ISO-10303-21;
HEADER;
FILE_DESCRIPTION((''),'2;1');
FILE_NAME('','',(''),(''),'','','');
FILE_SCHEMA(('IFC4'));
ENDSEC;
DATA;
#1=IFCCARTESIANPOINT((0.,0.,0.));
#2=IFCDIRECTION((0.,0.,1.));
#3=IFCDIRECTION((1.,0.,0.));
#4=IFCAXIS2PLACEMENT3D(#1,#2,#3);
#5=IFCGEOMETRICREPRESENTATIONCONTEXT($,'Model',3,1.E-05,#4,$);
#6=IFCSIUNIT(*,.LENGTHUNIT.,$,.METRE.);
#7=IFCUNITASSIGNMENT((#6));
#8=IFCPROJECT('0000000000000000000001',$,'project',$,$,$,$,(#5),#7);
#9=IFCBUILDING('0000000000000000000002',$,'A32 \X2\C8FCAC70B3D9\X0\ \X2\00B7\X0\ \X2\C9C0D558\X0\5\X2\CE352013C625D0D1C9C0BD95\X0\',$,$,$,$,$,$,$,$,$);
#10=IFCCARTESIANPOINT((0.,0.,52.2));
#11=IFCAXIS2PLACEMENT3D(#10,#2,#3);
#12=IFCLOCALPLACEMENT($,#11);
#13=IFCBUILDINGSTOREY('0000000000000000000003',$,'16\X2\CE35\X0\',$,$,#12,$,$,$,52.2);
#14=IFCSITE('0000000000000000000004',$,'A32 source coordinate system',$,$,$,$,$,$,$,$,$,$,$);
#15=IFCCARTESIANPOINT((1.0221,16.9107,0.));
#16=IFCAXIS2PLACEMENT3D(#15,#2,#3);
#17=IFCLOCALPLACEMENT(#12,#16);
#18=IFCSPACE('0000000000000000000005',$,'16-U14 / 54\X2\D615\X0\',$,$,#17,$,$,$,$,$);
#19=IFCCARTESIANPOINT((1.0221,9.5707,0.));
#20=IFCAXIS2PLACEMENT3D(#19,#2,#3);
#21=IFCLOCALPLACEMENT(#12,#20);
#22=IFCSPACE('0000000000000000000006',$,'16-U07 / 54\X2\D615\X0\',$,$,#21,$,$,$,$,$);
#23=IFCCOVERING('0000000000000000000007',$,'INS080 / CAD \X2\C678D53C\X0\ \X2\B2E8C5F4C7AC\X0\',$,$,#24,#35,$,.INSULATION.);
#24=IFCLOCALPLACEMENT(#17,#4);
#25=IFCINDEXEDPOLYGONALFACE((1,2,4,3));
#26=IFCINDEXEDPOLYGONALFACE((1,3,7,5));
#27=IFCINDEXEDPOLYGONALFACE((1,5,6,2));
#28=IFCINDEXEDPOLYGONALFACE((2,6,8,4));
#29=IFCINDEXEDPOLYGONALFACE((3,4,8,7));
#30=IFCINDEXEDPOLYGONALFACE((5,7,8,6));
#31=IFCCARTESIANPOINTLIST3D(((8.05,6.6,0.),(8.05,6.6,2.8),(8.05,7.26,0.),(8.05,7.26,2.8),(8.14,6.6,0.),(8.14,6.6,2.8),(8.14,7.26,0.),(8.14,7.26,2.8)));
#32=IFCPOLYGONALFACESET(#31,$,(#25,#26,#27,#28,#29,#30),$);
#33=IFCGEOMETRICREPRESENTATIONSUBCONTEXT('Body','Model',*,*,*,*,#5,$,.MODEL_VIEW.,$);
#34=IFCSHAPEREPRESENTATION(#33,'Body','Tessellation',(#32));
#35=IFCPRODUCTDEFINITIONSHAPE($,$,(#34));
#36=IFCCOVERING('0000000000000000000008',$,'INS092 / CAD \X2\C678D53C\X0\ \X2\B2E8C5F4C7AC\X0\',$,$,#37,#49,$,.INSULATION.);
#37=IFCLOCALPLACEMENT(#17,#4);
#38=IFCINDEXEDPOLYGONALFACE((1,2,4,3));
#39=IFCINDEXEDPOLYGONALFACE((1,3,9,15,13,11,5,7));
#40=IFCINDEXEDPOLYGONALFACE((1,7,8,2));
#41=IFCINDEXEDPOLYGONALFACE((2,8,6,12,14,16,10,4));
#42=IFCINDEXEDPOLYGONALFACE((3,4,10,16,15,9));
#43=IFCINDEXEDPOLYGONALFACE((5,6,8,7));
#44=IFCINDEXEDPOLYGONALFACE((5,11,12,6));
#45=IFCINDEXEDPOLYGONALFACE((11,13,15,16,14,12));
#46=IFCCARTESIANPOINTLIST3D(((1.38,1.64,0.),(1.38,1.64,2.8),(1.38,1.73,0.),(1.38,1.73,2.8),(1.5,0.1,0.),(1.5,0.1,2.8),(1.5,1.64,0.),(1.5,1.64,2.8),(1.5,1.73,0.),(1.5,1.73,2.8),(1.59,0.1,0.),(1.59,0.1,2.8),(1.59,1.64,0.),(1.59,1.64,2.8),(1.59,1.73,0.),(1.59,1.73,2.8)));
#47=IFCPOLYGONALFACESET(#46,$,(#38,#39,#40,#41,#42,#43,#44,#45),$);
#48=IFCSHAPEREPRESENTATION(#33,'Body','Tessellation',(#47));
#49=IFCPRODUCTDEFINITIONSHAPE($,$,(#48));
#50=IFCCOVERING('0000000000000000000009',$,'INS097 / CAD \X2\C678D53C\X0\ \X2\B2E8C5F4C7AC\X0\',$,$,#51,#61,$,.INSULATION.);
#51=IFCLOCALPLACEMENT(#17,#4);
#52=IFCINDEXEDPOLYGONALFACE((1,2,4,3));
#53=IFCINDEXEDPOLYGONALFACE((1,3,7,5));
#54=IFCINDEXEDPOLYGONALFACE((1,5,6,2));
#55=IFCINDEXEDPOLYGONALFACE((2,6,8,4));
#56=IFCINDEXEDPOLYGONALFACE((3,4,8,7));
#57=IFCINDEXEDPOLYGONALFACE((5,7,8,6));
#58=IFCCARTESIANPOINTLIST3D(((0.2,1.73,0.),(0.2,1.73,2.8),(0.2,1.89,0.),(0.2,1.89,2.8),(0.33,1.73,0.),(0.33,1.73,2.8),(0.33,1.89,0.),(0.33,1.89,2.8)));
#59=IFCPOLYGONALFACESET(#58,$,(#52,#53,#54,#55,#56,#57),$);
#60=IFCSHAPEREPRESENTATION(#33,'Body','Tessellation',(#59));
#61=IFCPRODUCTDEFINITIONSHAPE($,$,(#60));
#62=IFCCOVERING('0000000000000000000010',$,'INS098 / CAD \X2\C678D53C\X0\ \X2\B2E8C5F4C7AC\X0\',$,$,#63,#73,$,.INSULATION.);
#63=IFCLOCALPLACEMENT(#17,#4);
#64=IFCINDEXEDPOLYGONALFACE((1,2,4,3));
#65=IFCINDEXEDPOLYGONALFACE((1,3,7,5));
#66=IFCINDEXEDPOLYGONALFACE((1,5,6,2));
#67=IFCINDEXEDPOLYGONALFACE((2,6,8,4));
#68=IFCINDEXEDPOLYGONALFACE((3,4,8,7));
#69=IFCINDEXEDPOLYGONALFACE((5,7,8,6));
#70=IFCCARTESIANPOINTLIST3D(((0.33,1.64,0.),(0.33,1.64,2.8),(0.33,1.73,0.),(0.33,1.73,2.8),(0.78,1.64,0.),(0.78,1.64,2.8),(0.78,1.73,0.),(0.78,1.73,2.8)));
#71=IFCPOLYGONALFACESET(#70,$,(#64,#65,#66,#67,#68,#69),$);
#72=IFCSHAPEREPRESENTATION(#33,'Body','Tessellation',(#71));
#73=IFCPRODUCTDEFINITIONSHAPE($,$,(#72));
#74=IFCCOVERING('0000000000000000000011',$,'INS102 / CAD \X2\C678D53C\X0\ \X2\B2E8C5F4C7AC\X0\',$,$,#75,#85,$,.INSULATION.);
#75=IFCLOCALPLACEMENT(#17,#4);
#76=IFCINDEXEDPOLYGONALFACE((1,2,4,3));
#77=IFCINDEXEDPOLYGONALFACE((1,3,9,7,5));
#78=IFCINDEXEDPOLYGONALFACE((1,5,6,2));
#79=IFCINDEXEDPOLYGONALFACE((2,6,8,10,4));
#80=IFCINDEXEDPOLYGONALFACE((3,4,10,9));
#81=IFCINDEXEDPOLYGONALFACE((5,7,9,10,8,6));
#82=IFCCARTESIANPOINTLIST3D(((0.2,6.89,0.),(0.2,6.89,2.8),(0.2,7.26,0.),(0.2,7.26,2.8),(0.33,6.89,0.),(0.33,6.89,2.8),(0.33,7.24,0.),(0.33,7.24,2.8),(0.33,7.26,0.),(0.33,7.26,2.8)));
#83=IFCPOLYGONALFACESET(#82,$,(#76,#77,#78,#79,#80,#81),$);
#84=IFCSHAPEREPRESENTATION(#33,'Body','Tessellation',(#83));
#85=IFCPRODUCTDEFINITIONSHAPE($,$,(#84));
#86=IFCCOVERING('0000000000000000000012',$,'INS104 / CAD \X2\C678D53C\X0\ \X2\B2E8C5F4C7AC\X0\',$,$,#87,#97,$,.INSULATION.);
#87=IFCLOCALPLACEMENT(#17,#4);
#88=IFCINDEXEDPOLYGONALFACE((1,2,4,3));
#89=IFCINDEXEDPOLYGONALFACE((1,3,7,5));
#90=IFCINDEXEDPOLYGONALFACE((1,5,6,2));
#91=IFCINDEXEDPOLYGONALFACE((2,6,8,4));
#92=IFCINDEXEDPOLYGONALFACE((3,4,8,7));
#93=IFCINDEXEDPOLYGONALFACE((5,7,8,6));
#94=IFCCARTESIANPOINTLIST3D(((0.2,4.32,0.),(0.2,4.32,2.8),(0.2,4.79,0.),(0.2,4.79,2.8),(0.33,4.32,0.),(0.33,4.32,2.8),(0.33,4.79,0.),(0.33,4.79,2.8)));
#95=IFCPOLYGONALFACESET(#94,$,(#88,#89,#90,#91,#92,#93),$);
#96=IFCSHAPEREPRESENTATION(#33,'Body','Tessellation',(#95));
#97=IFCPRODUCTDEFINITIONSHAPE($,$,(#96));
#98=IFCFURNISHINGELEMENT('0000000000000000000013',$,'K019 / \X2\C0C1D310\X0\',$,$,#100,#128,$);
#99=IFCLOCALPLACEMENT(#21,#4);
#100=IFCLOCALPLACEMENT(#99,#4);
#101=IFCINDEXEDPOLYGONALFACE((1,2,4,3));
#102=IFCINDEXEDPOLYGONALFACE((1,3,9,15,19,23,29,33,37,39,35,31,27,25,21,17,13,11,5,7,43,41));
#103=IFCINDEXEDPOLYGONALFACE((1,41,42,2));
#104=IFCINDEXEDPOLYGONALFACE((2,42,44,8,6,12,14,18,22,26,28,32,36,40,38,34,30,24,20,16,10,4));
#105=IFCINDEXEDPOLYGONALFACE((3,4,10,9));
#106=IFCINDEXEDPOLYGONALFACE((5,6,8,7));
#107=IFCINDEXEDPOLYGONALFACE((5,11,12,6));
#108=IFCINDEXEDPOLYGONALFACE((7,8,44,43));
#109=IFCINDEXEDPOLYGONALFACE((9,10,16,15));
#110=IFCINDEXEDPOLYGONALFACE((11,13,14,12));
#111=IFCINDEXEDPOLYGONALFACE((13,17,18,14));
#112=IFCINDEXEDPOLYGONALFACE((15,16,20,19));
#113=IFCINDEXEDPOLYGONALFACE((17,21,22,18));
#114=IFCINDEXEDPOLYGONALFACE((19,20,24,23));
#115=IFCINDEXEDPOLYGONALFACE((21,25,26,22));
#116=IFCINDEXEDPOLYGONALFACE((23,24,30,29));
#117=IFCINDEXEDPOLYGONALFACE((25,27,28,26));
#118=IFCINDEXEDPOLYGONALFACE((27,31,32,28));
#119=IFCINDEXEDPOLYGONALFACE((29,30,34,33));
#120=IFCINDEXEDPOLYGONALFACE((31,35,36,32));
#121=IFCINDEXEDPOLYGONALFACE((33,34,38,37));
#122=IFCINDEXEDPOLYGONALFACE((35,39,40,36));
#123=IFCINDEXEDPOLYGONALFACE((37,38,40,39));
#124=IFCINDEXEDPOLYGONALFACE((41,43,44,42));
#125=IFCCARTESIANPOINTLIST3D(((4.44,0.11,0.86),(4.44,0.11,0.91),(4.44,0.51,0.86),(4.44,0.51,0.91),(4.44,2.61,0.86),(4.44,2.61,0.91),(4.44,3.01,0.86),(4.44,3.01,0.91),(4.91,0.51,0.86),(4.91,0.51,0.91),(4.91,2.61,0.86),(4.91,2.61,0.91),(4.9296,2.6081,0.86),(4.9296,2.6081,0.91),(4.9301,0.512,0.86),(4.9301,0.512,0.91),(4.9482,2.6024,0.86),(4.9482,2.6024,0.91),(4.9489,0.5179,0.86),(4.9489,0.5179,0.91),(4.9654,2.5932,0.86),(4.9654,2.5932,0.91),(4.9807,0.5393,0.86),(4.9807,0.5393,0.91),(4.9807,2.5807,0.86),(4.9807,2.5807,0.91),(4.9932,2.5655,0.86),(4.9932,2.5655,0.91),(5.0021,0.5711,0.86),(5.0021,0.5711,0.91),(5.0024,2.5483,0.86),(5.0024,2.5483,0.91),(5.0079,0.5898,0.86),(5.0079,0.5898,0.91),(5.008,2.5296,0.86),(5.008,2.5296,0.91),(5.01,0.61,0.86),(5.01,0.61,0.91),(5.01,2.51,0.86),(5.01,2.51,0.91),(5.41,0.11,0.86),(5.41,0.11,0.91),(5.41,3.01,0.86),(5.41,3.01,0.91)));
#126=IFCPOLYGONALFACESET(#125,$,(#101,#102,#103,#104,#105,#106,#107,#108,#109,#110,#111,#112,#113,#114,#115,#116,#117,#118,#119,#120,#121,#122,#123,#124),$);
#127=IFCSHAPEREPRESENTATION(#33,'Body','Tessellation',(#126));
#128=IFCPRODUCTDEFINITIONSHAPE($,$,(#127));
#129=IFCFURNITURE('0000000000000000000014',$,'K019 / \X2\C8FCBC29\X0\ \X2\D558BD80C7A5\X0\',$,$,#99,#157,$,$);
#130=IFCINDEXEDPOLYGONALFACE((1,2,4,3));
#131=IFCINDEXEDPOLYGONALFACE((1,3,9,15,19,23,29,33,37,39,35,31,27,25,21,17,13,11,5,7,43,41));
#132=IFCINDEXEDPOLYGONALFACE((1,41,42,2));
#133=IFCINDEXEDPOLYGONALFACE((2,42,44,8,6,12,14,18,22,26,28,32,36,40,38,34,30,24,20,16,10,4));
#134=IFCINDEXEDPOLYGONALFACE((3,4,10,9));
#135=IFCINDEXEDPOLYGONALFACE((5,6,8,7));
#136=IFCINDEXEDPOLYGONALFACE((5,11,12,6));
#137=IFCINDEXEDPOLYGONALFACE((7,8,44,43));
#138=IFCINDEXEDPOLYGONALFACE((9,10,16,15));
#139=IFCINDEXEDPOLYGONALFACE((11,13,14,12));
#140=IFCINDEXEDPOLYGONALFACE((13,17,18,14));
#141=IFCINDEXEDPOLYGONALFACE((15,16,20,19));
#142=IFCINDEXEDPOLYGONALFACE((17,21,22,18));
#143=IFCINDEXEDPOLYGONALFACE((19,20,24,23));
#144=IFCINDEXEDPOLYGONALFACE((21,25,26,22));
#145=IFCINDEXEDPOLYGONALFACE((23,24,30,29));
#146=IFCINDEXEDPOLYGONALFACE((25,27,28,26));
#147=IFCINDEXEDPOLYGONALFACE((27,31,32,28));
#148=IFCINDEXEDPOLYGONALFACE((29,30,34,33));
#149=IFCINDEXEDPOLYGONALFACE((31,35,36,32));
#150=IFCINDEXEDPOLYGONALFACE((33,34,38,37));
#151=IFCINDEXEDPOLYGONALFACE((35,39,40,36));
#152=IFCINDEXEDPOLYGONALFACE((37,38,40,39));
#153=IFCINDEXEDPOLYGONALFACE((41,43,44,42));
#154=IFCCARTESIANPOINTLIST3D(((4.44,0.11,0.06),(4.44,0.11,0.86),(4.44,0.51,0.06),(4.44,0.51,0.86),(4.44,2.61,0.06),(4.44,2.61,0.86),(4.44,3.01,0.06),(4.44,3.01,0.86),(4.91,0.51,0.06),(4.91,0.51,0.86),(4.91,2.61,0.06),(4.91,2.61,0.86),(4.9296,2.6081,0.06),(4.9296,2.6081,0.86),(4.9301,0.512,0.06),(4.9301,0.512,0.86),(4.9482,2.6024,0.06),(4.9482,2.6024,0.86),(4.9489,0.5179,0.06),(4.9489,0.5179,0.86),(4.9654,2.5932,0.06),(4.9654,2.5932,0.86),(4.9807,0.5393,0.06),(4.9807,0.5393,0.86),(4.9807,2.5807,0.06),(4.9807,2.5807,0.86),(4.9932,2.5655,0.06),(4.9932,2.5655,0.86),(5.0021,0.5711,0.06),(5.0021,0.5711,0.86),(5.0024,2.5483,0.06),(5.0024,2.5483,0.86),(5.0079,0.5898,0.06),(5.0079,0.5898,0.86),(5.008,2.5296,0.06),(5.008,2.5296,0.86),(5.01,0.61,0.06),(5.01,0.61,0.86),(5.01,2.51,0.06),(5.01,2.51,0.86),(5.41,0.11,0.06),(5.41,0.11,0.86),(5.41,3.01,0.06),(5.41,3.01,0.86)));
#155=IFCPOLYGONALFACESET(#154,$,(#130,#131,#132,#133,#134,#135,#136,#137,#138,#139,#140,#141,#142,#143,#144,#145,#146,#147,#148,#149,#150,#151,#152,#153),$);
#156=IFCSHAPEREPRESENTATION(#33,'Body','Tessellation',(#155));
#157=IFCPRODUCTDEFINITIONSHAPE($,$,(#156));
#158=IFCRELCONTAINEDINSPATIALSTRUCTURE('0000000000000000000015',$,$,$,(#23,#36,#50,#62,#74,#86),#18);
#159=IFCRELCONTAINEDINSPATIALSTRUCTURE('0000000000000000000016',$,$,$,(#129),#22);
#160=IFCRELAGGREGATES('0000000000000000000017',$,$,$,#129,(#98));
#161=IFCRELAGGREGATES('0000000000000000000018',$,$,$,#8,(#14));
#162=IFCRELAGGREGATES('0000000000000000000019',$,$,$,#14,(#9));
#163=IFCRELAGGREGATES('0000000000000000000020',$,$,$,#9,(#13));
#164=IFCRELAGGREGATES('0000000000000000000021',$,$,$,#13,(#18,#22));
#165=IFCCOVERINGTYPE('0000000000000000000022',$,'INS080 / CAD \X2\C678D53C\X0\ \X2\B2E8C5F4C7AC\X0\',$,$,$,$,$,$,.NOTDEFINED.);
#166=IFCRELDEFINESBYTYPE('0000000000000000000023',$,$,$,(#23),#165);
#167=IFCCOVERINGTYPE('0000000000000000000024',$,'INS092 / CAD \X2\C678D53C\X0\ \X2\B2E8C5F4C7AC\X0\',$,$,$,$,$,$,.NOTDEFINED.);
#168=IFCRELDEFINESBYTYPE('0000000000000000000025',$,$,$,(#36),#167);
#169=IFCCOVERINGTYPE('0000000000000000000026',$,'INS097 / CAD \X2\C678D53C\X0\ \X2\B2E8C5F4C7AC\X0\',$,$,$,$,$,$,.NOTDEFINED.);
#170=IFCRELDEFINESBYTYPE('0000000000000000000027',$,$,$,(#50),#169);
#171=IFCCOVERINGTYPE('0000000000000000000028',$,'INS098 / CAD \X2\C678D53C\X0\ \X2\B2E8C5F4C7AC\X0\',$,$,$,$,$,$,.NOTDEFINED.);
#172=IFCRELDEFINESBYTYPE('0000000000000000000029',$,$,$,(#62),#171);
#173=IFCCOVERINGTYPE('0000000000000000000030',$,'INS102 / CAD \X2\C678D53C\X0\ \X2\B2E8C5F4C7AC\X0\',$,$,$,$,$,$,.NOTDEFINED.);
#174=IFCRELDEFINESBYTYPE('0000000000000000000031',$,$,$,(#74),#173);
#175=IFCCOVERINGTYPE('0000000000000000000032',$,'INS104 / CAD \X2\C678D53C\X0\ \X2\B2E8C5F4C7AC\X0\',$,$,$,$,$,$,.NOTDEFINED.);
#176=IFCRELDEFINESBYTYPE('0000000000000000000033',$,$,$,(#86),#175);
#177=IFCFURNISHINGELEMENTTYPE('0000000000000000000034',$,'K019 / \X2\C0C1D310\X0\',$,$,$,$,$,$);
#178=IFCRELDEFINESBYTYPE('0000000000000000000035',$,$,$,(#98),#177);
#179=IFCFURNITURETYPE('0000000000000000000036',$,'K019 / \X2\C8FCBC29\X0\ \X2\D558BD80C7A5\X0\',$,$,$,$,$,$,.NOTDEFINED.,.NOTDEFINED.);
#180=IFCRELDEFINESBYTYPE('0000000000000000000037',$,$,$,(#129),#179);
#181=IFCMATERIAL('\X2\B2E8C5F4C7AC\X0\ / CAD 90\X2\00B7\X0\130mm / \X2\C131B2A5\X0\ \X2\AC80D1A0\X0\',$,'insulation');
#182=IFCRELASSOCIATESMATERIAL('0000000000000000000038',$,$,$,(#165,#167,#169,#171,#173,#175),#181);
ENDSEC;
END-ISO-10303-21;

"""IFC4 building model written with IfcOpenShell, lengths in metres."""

from ifc_helpers import new_model, si_unit, frame, origin, origin_with_axes, place, context, subcontext, project, spatial, polyline, outline, extrude, source, transform, mapped, material, type_object, type_shapes, element, aggregate, save


model = new_model("IFC4")

# Units and contexts
model_context = context("Model", 3, precision=1e-05, world=origin_with_axes())
body_context = subcontext(model_context, "Body", "Model", "MODEL_VIEW")
ifc_project = project(units=[si_unit("LENGTHUNIT", "METRE")], contexts=[model_context])

# Site, building, storey, space
storey_placement = place(None, frame((0.0, 0.0, 52.2), z_axis=(0.0, 0.0, 1.0), x_axis=(1.0, 0.0, 0.0)))
space_1_placement = place(storey_placement, frame((1.0221, 16.9107, 0.0), z_axis=(0.0, 0.0, 1.0), x_axis=(1.0, 0.0, 0.0)))
site = spatial("IfcSite", under=ifc_project, Name="A32 source coordinate system")
building = spatial("IfcBuilding", under=site, Name="A32 주거동 · 지하5층–옥탑지붕")
storey = spatial("IfcBuildingStorey", under=building, at=storey_placement, Name="16층", Elevation=52.2)
space_1 = spatial("IfcSpace", under=storey, at=space_1_placement, Name="16-U14 / 54형")

# Coverings
ifc_material = material(Name="단열재 / CAD 90·130mm / 성능 검토", Category="insulation")
covering_type_1 = type_object("IfcCoveringType", Name="INS080 / CAD 외피 단열재", PredefinedType="NOTDEFINED", material=ifc_material)
shared_shape_1 = source(origin(), body_context, "Body", "SweptSolid", [
    extrude(outline(polyline([(8.14, 7.26), (8.14, 6.6), (8.05, 6.6), (8.05, 7.26), (8.14, 7.26)])), origin(), (0.0, 0.0, 1.0), 2.8),
])
type_shapes(covering_type_1, [shared_shape_1])
covering_1_placement = place(space_1_placement, origin_with_axes())
element("IfcCovering", 1, at=covering_1_placement, inside=space_1, type_object=covering_type_1, Name="INS080 / CAD 외피 단열재", PredefinedType="INSULATION", context=body_context, shape_type="MappedRepresentation", body=[
    mapped(shared_shape_1, transform((0.0, 0.0, 0.0), scale=1.0)),
])
covering_type_2 = type_object("IfcCoveringType", Name="INS092 / CAD 외피 단열재", PredefinedType="NOTDEFINED", material=ifc_material)
shared_shape_2 = source(origin(), body_context, "Body", "SweptSolid", [
    extrude(outline(polyline([(1.59, 1.73), (1.59, 1.64), (1.59, 0.1), (1.5, 0.1), (1.5, 1.64), (1.38, 1.64), (1.38, 1.73), (1.5, 1.73), (1.59, 1.73)])), origin(), (0.0, 0.0, 1.0), 2.8),
])
type_shapes(covering_type_2, [shared_shape_2])
covering_2_placement = place(space_1_placement, origin_with_axes())
element("IfcCovering", 2, at=covering_2_placement, inside=space_1, type_object=covering_type_2, Name="INS092 / CAD 외피 단열재", PredefinedType="INSULATION", context=body_context, shape_type="MappedRepresentation", body=[
    mapped(shared_shape_2, transform((0.0, 0.0, 0.0), scale=1.0)),
])
covering_type_3 = type_object("IfcCoveringType", Name="INS097 / CAD 외피 단열재", PredefinedType="NOTDEFINED", material=ifc_material)
shared_shape_3 = source(origin(), body_context, "Body", "SweptSolid", [
    extrude(outline(polyline([(0.33, 1.89), (0.33, 1.73), (0.2, 1.73), (0.2, 1.89), (0.33, 1.89)])), origin(), (0.0, 0.0, 1.0), 2.8),
])
type_shapes(covering_type_3, [shared_shape_3])
covering_3_placement = place(space_1_placement, origin_with_axes())
element("IfcCovering", 3, at=covering_3_placement, inside=space_1, type_object=covering_type_3, Name="INS097 / CAD 외피 단열재", PredefinedType="INSULATION", context=body_context, shape_type="MappedRepresentation", body=[
    mapped(shared_shape_3, transform((0.0, 0.0, 0.0), scale=1.0)),
])
covering_type_4 = type_object("IfcCoveringType", Name="INS098 / CAD 외피 단열재", PredefinedType="NOTDEFINED", material=ifc_material)
shared_shape_4 = source(origin(), body_context, "Body", "SweptSolid", [
    extrude(outline(polyline([(0.78, 1.73), (0.78, 1.64), (0.33, 1.64), (0.33, 1.73), (0.78, 1.73)])), origin(), (0.0, 0.0, 1.0), 2.8),
])
type_shapes(covering_type_4, [shared_shape_4])
covering_4_placement = place(space_1_placement, origin_with_axes())
element("IfcCovering", 4, at=covering_4_placement, inside=space_1, type_object=covering_type_4, Name="INS098 / CAD 외피 단열재", PredefinedType="INSULATION", context=body_context, shape_type="MappedRepresentation", body=[
    mapped(shared_shape_4, transform((0.0, 0.0, 0.0), scale=1.0)),
])
covering_type_5 = type_object("IfcCoveringType", Name="INS102 / CAD 외피 단열재", PredefinedType="NOTDEFINED", material=ifc_material)
shared_shape_5 = source(origin(), body_context, "Body", "SweptSolid", [
    extrude(outline(polyline([(0.33, 7.26), (0.33, 7.24), (0.33, 6.89), (0.2, 6.89), (0.2, 7.26), (0.33, 7.26)])), origin(), (0.0, 0.0, 1.0), 2.8),
])
type_shapes(covering_type_5, [shared_shape_5])
covering_5_placement = place(space_1_placement, origin_with_axes())
element("IfcCovering", 5, at=covering_5_placement, inside=space_1, type_object=covering_type_5, Name="INS102 / CAD 외피 단열재", PredefinedType="INSULATION", context=body_context, shape_type="MappedRepresentation", body=[
    mapped(shared_shape_5, transform((0.0, 0.0, 0.0), scale=1.0)),
])
covering_type_6 = type_object("IfcCoveringType", Name="INS104 / CAD 외피 단열재", PredefinedType="NOTDEFINED", material=ifc_material)
shared_shape_6 = source(origin(), body_context, "Body", "SweptSolid", [
    extrude(outline(polyline([(0.33, 4.32), (0.2, 4.32), (0.2, 4.79), (0.33, 4.79), (0.33, 4.32)])), origin(), (0.0, 0.0, 1.0), 2.8),
])
type_shapes(covering_type_6, [shared_shape_6])
covering_6_placement = place(space_1_placement, origin_with_axes())
element("IfcCovering", 6, at=covering_6_placement, inside=space_1, type_object=covering_type_6, Name="INS104 / CAD 외피 단열재", PredefinedType="INSULATION", context=body_context, shape_type="MappedRepresentation", body=[
    mapped(shared_shape_6, transform((0.0, 0.0, 0.0), scale=1.0)),
])

# Furnishing element
furnishing_element_type = type_object("IfcFurnishingElementType", Name="K019 / 상판")
shared_shape_7 = source(origin(), body_context, "Body", "SweptSolid", [
    extrude(outline(polyline([(4.91, 0.51), (4.9301, 0.512), (4.9489, 0.5179), (4.9807, 0.5393), (5.0021, 0.5711), (5.0079, 0.5898), (5.01, 0.61), (5.01, 2.51), (5.008, 2.5296), (5.0024, 2.5483), (4.9932, 2.5655), (4.9807, 2.5807), (4.9654, 2.5932), (4.9482, 2.6024), (4.9296, 2.6081), (4.91, 2.61), (4.44, 2.61), (4.44, 3.01), (5.41, 3.01), (5.41, 0.11), (4.44, 0.11), (4.44, 0.51), (4.91, 0.51)])), frame((0.0, 0.0, 0.86)), (0.0, 0.0, 1.0), 0.05),
])
type_shapes(furnishing_element_type, [shared_shape_7])
space_2_placement = place(storey_placement, frame((1.0221, 9.5707, 0.0), z_axis=(0.0, 0.0, 1.0), x_axis=(1.0, 0.0, 0.0)))
furniture_placement = place(space_2_placement, origin_with_axes())
furnishing_placement = place(furniture_placement, origin_with_axes())
furnishing = element("IfcFurnishingElement", 7, at=furnishing_placement, type_object=furnishing_element_type, Name="K019 / 상판", context=body_context, shape_type="MappedRepresentation", body=[
    mapped(shared_shape_7, transform((0.0, 0.0, 0.0), scale=1.0)),
])

# Shared definitions
space_2 = spatial("IfcSpace", under=storey, at=space_2_placement, Name="16-U07 / 54형")

# Furniture
furniture_type = type_object("IfcFurnitureType", Name="K019 / 주방 하부장", AssemblyPlace="NOTDEFINED", PredefinedType="NOTDEFINED")
shared_shape_8 = source(origin(), body_context, "Body", "SweptSolid", [
    extrude(outline(polyline([(4.44, 0.51), (4.91, 0.51), (4.9301, 0.512), (4.9489, 0.5179), (4.9807, 0.5393), (5.0021, 0.5711), (5.0079, 0.5898), (5.01, 0.61), (5.01, 2.51), (5.008, 2.5296), (5.0024, 2.5483), (4.9932, 2.5655), (4.9807, 2.5807), (4.9654, 2.5932), (4.9482, 2.6024), (4.9296, 2.6081), (4.91, 2.61), (4.44, 2.61), (4.44, 3.01), (5.41, 3.01), (5.41, 0.11), (4.44, 0.11), (4.44, 0.51)])), frame((0.0, 0.0, 0.06)), (0.0, 0.0, 1.0), 0.8),
])
type_shapes(furniture_type, [shared_shape_8])
furniture = element("IfcFurniture", 8, at=furniture_placement, inside=space_2, type_object=furniture_type, Name="K019 / 주방 하부장", context=body_context, shape_type="MappedRepresentation", body=[
    mapped(shared_shape_8, transform((0.0, 0.0, 0.0), scale=1.0)),
])
aggregate(furniture, [furnishing])

save(model, "model.ifc")
